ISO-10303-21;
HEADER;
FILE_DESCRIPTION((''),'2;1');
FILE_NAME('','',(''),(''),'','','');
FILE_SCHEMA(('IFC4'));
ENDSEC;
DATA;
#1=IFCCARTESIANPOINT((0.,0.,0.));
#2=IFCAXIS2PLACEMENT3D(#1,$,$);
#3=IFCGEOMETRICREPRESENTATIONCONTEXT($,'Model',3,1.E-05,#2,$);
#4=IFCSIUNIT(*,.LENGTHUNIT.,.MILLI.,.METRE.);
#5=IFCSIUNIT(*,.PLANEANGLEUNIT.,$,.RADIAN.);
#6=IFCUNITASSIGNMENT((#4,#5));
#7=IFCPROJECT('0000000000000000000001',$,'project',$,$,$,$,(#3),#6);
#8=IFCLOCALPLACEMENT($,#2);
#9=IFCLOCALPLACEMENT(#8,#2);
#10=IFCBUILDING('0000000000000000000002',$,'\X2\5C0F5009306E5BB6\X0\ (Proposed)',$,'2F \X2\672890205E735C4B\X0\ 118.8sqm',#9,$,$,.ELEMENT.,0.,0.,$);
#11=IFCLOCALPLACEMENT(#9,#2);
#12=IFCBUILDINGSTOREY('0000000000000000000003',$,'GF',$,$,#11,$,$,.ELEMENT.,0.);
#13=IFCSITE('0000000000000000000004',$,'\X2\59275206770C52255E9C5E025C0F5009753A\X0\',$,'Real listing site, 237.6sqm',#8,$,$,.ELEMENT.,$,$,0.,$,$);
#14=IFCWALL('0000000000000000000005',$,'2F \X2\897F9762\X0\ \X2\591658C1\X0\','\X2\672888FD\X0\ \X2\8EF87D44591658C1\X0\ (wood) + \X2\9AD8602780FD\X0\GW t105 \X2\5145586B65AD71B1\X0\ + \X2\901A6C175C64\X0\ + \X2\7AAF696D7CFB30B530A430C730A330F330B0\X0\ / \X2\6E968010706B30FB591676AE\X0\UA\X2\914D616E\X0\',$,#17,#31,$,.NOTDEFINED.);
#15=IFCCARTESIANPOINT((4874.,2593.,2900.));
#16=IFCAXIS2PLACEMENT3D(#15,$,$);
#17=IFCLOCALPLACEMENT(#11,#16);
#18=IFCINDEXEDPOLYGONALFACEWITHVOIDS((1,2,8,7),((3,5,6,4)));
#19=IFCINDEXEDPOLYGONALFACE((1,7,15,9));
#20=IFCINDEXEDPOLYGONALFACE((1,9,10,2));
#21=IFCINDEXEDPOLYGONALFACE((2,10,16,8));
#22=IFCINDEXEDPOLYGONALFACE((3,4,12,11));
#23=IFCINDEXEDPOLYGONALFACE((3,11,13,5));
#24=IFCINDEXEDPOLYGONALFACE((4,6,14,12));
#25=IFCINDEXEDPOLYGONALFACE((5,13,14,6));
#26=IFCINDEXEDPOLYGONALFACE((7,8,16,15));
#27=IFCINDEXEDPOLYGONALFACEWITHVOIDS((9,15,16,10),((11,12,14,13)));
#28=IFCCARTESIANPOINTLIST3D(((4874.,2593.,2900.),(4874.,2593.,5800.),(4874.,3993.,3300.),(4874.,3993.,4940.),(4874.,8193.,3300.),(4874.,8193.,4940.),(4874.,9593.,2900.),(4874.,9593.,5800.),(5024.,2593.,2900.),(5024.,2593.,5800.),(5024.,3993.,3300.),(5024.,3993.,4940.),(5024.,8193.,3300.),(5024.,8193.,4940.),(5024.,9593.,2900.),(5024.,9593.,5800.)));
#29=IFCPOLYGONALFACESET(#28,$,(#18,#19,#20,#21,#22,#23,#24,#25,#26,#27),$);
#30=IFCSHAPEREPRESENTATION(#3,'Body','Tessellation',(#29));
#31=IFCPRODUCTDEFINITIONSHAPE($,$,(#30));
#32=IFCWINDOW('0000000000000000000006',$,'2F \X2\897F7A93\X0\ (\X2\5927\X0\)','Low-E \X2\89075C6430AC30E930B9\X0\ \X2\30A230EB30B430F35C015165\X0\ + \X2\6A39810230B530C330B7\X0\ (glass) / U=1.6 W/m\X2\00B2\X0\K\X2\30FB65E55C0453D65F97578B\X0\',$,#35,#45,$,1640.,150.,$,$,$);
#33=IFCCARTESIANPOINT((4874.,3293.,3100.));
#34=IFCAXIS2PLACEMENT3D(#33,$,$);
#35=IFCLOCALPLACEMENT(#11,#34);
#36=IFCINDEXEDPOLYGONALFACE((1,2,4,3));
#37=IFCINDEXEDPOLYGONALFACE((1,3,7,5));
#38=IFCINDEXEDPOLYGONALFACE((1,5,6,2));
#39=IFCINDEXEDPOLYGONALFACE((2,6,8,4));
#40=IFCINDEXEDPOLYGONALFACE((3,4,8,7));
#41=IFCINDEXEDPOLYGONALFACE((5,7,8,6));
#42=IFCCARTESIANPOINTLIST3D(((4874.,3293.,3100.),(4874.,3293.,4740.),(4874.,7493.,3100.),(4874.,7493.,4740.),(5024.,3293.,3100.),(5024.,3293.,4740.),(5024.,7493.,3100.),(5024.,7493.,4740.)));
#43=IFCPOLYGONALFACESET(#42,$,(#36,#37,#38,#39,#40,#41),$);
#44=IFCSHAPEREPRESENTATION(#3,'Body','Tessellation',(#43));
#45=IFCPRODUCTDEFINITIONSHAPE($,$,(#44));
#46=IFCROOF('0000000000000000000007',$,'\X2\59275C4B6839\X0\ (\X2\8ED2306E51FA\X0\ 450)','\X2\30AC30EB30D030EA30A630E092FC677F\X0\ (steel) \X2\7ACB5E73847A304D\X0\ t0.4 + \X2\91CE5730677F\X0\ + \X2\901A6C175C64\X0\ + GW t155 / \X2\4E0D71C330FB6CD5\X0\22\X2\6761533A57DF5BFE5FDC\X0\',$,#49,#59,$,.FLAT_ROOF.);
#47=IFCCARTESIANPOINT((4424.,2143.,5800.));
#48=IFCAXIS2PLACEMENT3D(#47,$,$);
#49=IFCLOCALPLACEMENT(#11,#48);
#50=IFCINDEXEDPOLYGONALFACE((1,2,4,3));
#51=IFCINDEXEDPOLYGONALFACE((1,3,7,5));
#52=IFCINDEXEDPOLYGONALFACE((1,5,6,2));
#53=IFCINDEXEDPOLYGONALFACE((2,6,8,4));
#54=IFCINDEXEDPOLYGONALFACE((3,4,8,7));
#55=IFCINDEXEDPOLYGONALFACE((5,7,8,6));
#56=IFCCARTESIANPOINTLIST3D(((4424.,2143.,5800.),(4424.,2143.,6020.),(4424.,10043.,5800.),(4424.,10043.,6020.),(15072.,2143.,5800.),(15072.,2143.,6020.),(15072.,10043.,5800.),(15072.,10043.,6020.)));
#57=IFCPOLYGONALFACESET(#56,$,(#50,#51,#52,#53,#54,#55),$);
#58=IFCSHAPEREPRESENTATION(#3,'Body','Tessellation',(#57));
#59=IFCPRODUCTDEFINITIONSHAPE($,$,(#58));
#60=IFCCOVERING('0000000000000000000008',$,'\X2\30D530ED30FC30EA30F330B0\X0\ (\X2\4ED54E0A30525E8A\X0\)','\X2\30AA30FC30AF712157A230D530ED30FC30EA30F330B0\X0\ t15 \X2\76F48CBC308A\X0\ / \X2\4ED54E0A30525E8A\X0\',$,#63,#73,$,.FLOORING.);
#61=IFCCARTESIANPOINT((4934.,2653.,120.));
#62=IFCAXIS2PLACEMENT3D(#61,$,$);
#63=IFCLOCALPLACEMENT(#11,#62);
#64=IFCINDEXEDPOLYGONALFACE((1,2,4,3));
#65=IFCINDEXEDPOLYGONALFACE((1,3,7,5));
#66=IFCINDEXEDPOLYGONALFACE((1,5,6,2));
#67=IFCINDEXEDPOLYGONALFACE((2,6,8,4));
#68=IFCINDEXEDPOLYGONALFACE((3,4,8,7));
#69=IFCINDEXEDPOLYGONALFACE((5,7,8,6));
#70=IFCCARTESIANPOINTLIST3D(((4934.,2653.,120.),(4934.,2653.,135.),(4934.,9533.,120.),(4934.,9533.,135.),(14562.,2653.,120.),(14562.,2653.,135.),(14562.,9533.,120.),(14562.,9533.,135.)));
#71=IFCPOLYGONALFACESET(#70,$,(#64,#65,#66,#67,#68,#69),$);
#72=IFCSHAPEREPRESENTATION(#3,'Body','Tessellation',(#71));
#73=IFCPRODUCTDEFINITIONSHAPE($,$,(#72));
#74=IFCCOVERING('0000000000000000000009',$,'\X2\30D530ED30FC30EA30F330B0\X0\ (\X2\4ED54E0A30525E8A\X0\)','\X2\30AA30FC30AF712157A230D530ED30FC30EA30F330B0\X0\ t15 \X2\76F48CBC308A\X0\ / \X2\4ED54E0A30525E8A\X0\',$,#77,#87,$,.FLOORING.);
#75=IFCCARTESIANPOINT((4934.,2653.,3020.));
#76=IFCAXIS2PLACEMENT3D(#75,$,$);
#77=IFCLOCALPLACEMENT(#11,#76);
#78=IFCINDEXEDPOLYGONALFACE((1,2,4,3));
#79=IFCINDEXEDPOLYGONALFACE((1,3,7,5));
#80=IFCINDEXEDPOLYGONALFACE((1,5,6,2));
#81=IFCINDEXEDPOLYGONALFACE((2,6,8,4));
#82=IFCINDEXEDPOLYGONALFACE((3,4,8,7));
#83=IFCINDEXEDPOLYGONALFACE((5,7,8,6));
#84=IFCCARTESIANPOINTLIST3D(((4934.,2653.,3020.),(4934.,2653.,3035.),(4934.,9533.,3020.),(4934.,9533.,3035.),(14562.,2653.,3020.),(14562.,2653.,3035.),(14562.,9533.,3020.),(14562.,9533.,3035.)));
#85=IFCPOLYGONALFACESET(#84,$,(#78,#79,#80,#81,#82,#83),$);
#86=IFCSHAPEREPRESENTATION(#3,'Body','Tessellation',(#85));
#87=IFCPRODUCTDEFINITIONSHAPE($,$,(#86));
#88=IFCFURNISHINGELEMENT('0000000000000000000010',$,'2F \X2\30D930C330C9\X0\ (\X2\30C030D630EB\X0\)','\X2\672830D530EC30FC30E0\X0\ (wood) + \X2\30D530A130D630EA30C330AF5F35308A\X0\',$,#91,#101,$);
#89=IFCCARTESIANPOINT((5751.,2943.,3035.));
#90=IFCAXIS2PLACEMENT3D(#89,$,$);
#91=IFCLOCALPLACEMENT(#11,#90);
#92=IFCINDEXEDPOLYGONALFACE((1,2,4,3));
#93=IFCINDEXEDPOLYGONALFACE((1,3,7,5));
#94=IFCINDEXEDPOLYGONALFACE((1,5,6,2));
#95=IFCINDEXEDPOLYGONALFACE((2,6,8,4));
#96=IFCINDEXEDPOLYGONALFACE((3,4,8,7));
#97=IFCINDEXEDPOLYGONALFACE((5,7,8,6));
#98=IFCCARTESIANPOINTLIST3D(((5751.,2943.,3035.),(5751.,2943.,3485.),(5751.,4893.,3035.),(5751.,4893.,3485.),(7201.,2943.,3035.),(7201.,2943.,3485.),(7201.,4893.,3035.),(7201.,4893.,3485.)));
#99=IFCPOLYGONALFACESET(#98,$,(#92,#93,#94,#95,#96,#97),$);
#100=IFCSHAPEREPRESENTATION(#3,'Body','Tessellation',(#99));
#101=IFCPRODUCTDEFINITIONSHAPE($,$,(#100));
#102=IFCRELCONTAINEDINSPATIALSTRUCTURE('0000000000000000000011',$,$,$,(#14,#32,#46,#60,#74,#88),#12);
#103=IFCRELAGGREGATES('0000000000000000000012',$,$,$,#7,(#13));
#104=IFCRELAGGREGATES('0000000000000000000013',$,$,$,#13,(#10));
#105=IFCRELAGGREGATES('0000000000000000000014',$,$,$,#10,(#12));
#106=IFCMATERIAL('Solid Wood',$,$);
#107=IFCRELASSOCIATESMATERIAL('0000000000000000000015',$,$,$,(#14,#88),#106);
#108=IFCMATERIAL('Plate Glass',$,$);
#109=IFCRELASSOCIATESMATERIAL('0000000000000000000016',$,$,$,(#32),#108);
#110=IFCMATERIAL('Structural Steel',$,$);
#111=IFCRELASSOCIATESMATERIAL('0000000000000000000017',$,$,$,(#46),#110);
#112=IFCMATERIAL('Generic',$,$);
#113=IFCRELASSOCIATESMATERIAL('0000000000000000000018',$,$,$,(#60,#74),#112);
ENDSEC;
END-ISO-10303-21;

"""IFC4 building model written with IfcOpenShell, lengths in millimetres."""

from ifc_helpers import new_model, si_unit, frame, frame_2d, origin, place, context, project, spatial, rectangle, extrude, material, element, fill, save


model = new_model("IFC4")

# Units and contexts
model_context = context("Model", 3, precision=1e-05, world=origin())
ifc_project = project(units=[si_unit("LENGTHUNIT", "METRE", prefix="MILLI"), si_unit("PLANEANGLEUNIT", "RADIAN")], contexts=[model_context])

# Site, building, storey
site_placement = place(None, origin())
site = spatial("IfcSite", under=ifc_project, at=site_placement, Name="大分県別府市小倉町", ObjectType="Real listing site, 237.6sqm", CompositionType="ELEMENT", RefElevation=0.0)
building_placement = place(site_placement, origin())
building = spatial("IfcBuilding", under=site, at=building_placement, Name="小倉の家 (Proposed)", ObjectType="2F 木造平屋 118.8sqm", CompositionType="ELEMENT", ElevationOfRefHeight=0.0, ElevationOfTerrain=0.0)
storey_placement = place(building_placement, origin())
storey = spatial("IfcBuildingStorey", under=building, at=storey_placement, Name="GF", CompositionType="ELEMENT", Elevation=0.0)

# Shared definitions
ifc_material_1 = material(Name="Solid Wood")

# Shared definitions
ifc_material_2 = material(Name="Plate Glass")

# Wall, opening, window
wall_1_placement = place(storey_placement, frame((4874.0, 2593.0, 2900.0)))
wall_1 = element("IfcWall", 1, at=wall_1_placement, inside=storey, material=ifc_material_1, Name="2F 西面 外壁", Description="木製 軸組外壁 (wood) + 高性能GW t105 充填断熱 + 通気層 + 窯業系サイディング / 準耐火・外皮UA配慮", PredefinedType="NOTDEFINED", context=model_context, shape_type="SweptSolid", body=[
    extrude(rectangle(XDim=150.0, YDim=7000.0, at=frame_2d((75.0, 3500.0))), frame((4874.0, 2593.0, 2900.0)), (0.0, 0.0, 1.0), 2900.0),
])
opening_1_placement = place(storey_placement, frame((4874.0, 3293.0, 3100.0)))
opening_1 = element("IfcOpeningElement", 2, at=opening_1_placement, cuts=wall_1, PredefinedType="NOTDEFINED", context=model_context, shape_type="SweptSolid", body=[
    extrude(rectangle(XDim=150.0, YDim=4200.0, at=frame_2d((75.0, 2100.0))), frame((4874.0, 3293.0, 3100.0)), (0.0, 0.0, 1.0), 1640.0),
])
window_1_placement = place(storey_placement, frame((4874.0, 3293.0, 3100.0)))
window_1 = element("IfcWindow", 3, at=window_1_placement, inside=storey, material=ifc_material_2, Name="2F 西窓 (大)", Description="Low-E 複層ガラス アルゴン封入 + 樹脂サッシ (glass) / U=1.6 W/m²K・日射取得型", OverallHeight=1640.0, OverallWidth=150.0, context=model_context, shape_type="SweptSolid", body=[
    extrude(rectangle(XDim=150.0, YDim=4200.0, at=frame_2d((75.0, 2100.0))), frame((4874.0, 3293.0, 3100.0)), (0.0, 0.0, 1.0), 1640.0),
])
fill(opening_1, window_1)

# Roof
ifc_material_3 = material(Name="Structural Steel")
roof_placement = place(storey_placement, frame((4424.0, 2143.0, 5800.0)))
element("IfcRoof", 4, at=roof_placement, inside=storey, material=ifc_material_3, Name="大屋根 (軒の出 450)", Description="ガルバリウム鋼板 (steel) 立平葺き t0.4 + 野地板 + 通気層 + GW t155 / 不燃・法22条区域対応", PredefinedType="FLAT_ROOF", context=model_context, shape_type="SweptSolid", body=[
    extrude(rectangle(XDim=10648.0, YDim=7900.0, at=frame_2d((5324.0, 3950.0))), frame((4424.0, 2143.0, 5800.0)), (0.0, 0.0, 1.0), 220.0),
])

# Coverings
ifc_material_4 = material(Name="Generic")
covering_1_placement = place(storey_placement, frame((4934.0, 2653.0, 120.0)))
element("IfcCovering", 5, at=covering_1_placement, inside=storey, material=ifc_material_4, Name="フローリング (仕上げ床)", Description="オーク無垢フローリング t15 直貼り / 仕上げ床", PredefinedType="FLOORING", context=model_context, shape_type="SweptSolid", body=[
    extrude(rectangle(XDim=9628.0, YDim=6880.0, at=frame_2d((4814.0, 3440.0))), frame((4934.0, 2653.0, 120.0)), (0.0, 0.0, 1.0), 15.0),
])
covering_2_placement = place(storey_placement, frame((4934.0, 2653.0, 3020.0)))
element("IfcCovering", 6, at=covering_2_placement, inside=storey, material=ifc_material_4, Name="フローリング (仕上げ床)", Description="オーク無垢フローリング t15 直貼り / 仕上げ床", PredefinedType="FLOORING", context=model_context, shape_type="SweptSolid", body=[
    extrude(rectangle(XDim=9628.0, YDim=6880.0, at=frame_2d((4814.0, 3440.0))), frame((4934.0, 2653.0, 3020.0)), (0.0, 0.0, 1.0), 15.0),
])

# Furnishing element
furnishing_placement = place(storey_placement, frame((5751.0, 2943.0, 3035.0)))
element("IfcFurnishingElement", 7, at=furnishing_placement, inside=storey, material=ifc_material_1, Name="2F ベッド (ダブル)", Description="木フレーム (wood) + ファブリック張り", context=model_context, shape_type="SweptSolid", body=[
    extrude(rectangle(XDim=1450.0, YDim=1950.0, at=frame_2d((725.0, 975.0))), frame((5751.0, 2943.0, 3035.0)), (0.0, 0.0, 1.0), 450.0),
])

save(model, "model.ifc")
